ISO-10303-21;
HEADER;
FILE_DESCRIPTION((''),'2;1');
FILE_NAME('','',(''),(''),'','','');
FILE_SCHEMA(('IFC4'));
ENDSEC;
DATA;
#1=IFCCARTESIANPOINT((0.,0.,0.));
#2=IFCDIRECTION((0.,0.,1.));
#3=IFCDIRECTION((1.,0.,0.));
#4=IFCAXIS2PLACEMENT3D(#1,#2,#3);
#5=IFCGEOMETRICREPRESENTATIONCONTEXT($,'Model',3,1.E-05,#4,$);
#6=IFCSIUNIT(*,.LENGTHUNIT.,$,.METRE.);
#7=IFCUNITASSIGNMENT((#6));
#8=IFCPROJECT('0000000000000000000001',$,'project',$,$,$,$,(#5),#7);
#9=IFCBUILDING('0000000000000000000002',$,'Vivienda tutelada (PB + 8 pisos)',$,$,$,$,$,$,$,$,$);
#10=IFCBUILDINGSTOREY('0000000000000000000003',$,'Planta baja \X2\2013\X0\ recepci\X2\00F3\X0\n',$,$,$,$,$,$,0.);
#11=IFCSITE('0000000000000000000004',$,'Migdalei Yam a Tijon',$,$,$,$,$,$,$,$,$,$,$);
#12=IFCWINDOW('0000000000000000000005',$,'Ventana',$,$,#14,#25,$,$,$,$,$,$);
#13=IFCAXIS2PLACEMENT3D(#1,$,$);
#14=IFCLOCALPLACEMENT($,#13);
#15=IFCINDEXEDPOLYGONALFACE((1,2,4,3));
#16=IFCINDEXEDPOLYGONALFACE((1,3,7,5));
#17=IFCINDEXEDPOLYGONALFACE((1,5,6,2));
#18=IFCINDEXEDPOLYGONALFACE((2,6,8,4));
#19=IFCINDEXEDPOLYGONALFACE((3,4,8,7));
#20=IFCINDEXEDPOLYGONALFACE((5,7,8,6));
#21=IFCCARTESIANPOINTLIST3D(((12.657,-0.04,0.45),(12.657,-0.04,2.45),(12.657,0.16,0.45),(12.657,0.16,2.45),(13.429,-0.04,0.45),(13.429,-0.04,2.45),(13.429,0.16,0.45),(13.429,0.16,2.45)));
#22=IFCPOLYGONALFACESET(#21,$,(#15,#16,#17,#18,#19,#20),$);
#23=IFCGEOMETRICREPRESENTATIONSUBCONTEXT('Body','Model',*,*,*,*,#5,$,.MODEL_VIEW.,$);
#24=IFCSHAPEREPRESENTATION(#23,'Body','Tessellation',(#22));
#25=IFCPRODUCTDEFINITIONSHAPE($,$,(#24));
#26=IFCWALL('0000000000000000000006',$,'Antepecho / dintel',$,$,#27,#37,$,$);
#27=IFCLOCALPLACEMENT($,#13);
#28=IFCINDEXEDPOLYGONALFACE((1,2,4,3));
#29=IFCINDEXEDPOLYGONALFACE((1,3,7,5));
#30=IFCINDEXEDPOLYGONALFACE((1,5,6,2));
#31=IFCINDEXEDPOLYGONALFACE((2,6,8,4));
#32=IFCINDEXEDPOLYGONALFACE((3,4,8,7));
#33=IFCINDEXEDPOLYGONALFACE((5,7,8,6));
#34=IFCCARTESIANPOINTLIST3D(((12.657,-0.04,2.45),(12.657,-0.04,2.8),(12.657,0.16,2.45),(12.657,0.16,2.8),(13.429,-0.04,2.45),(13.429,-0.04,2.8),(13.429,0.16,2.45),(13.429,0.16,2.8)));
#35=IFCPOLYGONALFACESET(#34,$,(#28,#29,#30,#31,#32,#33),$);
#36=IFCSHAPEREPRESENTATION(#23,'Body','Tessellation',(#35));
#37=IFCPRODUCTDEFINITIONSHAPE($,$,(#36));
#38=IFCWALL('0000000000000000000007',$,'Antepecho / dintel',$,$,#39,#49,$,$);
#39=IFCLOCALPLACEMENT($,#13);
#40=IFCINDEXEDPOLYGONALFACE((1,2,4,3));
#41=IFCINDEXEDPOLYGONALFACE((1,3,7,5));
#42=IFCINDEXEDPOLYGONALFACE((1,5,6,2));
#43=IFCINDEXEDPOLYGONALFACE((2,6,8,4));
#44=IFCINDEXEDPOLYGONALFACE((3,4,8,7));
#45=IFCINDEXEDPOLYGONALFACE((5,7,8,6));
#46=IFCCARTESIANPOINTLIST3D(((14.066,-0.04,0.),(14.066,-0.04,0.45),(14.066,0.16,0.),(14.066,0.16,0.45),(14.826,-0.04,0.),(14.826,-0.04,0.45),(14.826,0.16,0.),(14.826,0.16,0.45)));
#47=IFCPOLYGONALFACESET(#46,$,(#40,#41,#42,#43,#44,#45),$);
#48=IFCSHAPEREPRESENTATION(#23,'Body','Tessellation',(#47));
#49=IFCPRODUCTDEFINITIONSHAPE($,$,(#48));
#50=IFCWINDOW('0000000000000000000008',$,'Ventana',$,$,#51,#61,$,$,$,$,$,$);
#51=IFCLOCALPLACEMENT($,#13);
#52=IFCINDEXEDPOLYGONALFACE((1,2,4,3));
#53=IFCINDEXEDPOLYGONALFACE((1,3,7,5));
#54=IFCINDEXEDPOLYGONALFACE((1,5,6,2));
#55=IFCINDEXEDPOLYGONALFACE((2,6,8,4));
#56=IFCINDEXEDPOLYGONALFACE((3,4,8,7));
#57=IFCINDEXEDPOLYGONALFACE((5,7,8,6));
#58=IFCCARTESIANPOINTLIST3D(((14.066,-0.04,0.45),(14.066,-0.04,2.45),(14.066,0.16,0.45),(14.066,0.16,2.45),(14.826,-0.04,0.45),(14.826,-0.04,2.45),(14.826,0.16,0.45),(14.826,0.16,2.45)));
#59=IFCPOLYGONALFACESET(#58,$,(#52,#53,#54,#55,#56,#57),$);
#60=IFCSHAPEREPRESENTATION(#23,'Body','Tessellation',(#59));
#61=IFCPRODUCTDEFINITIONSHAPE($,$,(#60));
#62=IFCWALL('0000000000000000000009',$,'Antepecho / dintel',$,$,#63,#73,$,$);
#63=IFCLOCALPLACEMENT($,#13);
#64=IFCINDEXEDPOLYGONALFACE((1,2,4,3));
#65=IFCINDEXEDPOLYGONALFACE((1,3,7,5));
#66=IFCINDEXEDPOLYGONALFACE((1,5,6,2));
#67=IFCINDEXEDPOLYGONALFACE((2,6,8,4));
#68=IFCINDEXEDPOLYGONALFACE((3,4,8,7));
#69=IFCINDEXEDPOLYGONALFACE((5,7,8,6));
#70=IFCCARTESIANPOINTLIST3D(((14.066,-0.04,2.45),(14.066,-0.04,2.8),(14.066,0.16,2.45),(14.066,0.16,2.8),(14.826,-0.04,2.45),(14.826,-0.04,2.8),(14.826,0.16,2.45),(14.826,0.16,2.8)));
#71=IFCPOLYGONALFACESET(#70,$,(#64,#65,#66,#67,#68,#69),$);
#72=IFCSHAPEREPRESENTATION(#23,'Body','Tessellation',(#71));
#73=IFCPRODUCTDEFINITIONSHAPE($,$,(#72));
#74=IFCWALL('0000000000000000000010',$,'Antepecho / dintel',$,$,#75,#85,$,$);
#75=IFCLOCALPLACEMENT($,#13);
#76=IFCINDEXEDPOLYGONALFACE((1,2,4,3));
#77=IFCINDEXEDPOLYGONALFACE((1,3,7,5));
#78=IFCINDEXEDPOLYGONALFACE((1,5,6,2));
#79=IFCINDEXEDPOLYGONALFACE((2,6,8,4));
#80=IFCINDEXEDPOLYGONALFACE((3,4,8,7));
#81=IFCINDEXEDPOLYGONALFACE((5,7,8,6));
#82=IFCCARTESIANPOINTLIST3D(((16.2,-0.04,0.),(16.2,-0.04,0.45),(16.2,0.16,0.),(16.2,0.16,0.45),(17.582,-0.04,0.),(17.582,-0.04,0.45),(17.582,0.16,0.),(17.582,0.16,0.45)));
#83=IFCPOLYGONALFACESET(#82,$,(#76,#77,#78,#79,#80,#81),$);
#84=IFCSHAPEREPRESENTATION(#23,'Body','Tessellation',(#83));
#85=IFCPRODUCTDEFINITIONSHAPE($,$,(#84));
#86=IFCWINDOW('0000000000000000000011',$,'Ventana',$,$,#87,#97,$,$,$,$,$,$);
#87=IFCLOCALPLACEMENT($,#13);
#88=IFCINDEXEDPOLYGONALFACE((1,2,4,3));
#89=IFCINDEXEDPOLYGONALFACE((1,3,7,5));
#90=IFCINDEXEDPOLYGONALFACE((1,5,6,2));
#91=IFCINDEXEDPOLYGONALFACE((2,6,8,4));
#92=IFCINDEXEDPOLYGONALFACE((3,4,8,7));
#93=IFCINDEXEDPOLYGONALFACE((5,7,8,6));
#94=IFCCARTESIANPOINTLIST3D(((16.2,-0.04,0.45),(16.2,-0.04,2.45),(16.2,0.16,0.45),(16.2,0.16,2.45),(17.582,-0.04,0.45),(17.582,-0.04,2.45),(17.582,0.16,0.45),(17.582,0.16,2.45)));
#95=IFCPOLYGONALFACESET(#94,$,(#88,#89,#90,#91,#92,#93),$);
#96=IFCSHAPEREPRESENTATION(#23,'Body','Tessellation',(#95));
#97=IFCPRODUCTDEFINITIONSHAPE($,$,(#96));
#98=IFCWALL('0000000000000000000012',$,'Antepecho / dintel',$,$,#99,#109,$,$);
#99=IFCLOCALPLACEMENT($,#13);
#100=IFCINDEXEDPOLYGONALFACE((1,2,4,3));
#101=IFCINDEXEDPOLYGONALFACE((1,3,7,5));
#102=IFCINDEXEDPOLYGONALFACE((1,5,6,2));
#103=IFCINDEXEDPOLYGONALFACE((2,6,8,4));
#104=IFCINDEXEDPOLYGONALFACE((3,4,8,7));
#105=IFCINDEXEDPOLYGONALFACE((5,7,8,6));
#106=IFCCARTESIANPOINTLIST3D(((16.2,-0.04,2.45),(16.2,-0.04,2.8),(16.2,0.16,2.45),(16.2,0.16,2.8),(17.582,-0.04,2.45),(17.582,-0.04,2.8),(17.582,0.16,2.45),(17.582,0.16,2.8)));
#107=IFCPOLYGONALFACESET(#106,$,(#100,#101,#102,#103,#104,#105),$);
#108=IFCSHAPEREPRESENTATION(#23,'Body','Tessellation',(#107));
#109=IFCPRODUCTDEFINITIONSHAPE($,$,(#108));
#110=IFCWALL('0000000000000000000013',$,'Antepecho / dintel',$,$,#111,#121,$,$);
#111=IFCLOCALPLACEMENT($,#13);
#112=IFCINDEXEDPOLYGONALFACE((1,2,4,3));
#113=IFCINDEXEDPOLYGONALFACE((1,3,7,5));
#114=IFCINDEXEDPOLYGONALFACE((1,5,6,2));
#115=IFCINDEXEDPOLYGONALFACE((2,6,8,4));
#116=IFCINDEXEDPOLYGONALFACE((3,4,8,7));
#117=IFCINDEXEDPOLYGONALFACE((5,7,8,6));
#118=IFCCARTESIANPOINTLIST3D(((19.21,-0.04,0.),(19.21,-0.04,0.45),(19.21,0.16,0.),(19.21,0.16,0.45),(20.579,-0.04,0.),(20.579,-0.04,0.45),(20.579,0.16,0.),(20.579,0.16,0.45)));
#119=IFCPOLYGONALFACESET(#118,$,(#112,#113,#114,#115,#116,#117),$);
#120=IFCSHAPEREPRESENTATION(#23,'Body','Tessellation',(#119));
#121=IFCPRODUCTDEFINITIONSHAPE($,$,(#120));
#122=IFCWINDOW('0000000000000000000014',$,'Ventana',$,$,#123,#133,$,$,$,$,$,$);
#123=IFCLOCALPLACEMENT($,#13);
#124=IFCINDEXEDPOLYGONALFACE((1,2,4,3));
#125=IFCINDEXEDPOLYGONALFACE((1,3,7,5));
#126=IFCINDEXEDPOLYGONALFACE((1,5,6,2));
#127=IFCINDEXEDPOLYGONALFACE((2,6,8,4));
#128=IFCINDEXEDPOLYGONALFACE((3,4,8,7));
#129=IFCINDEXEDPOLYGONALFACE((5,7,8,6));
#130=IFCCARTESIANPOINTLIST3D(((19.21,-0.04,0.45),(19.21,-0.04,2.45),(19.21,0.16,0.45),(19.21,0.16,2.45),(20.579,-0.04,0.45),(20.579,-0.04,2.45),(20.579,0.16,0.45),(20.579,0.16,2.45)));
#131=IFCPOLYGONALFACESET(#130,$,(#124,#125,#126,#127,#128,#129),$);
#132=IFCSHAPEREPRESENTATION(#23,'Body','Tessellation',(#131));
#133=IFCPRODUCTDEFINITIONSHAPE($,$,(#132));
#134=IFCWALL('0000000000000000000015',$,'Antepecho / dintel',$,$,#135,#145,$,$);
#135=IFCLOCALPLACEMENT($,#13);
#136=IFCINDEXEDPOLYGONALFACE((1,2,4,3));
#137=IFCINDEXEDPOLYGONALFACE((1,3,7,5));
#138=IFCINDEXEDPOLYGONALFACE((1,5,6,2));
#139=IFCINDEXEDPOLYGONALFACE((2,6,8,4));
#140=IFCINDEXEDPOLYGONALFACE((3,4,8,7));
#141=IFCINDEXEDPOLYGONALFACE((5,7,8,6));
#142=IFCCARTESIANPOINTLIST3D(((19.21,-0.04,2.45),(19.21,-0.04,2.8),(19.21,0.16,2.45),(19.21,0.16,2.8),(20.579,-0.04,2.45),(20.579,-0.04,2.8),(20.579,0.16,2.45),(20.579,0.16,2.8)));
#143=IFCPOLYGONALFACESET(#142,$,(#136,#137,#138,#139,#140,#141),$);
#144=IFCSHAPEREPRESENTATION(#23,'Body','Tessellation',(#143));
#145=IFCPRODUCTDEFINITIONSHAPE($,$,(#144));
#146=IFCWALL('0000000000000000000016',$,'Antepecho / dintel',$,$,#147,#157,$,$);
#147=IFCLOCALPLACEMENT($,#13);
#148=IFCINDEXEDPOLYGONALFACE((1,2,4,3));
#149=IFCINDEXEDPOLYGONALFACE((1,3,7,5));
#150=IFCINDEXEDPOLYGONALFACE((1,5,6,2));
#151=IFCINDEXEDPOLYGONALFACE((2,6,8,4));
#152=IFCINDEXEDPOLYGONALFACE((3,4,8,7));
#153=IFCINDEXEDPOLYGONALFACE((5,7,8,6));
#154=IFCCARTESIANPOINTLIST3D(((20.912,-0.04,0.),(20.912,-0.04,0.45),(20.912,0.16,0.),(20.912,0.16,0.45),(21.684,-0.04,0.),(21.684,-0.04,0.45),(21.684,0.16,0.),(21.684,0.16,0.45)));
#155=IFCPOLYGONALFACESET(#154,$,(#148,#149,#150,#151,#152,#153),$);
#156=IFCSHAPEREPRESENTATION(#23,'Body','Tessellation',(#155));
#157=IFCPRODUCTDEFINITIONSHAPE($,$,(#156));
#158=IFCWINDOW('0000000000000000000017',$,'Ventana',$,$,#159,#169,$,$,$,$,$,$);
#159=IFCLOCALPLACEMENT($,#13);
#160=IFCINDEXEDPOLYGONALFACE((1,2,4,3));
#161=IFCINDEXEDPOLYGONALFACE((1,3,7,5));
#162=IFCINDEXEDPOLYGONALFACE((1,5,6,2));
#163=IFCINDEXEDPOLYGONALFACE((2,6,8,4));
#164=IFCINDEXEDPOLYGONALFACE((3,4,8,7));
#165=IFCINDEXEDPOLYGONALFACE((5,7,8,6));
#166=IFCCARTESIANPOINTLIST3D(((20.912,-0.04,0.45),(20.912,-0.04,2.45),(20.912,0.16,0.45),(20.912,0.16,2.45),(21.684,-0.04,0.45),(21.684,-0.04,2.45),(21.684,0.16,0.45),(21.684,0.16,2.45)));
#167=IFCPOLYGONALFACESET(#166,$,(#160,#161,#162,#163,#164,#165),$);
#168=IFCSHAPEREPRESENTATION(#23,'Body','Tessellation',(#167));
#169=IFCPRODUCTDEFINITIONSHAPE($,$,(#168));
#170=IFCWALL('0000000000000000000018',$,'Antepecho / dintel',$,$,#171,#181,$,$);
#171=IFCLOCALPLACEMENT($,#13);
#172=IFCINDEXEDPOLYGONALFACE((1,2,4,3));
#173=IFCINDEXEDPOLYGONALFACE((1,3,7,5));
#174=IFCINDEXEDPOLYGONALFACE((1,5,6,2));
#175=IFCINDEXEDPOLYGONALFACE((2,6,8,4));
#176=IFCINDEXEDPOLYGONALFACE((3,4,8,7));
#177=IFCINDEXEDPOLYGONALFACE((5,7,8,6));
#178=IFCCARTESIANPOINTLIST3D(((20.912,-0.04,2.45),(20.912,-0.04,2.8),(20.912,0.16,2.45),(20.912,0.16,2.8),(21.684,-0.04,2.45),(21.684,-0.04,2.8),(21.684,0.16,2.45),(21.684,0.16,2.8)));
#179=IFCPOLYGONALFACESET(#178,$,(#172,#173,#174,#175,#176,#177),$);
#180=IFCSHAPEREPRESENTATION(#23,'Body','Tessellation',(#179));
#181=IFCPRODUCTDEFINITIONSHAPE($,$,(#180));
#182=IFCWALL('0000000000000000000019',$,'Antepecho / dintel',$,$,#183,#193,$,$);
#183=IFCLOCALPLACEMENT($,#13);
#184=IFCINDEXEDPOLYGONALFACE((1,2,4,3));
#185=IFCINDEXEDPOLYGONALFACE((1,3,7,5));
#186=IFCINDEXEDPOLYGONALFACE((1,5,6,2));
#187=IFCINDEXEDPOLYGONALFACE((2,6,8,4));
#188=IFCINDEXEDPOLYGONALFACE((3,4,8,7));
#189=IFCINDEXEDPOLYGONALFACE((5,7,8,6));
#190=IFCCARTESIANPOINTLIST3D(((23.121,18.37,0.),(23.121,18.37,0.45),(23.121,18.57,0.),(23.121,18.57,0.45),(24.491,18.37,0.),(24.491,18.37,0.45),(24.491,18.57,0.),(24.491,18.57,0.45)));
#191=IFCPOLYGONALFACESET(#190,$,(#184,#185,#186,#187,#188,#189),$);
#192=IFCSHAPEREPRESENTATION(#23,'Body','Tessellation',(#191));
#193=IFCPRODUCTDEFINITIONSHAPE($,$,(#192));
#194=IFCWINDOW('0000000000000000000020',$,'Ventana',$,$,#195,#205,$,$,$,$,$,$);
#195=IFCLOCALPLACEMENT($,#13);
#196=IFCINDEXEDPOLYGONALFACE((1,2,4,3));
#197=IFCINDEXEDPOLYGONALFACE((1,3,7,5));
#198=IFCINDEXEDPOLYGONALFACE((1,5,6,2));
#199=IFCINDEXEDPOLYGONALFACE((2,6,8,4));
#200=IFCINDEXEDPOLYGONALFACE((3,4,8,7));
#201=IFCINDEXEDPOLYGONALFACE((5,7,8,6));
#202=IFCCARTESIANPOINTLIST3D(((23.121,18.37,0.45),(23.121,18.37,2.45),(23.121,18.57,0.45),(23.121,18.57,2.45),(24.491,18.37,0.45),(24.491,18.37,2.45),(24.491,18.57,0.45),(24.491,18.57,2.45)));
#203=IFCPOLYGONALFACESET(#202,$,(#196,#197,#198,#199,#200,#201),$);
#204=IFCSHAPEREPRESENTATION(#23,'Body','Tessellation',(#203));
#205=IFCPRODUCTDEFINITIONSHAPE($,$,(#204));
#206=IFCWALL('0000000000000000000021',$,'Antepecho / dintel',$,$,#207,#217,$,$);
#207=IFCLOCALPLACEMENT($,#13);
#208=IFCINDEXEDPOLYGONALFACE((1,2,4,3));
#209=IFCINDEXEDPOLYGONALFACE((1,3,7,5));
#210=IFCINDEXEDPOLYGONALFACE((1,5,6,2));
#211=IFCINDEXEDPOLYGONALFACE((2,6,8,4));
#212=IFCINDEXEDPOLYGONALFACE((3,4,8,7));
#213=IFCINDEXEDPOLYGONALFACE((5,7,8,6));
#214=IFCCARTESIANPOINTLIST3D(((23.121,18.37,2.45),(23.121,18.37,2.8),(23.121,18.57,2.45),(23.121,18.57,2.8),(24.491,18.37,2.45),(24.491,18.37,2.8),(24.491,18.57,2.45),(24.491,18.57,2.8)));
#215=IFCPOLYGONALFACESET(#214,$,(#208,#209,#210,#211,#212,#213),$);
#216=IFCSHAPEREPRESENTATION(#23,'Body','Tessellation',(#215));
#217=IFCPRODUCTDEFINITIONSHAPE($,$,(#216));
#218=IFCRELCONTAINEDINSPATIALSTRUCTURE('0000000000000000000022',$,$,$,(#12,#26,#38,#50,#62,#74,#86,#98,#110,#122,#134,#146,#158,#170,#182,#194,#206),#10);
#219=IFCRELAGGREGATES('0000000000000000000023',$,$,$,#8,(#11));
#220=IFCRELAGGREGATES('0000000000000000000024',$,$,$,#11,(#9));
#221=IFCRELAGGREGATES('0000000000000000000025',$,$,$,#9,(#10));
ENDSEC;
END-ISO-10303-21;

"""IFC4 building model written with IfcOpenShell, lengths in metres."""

from ifc_helpers import new_model, si_unit, frame, origin_with_axes, context, subcontext, project, spatial, line, indexed_curve, outline, extrude, element, save


model = new_model("IFC4")

# Units and contexts
model_context = context("Model", 3, precision=1e-05, world=origin_with_axes())
body_context = subcontext(model_context, "Body", "Model", "MODEL_VIEW")
ifc_project = project(units=[si_unit("LENGTHUNIT", "METRE")], contexts=[model_context])

# Site, building, storey
site = spatial("IfcSite", under=ifc_project, Name="Migdalei Yam a Tijon")
building = spatial("IfcBuilding", under=site, Name="Vivienda tutelada (PB + 8 pisos)")
storey = spatial("IfcBuildingStorey", under=building, Name="Planta baja – recepción", Elevation=0.0)

# Window
element("IfcWindow", 1, inside=storey, Name="Ventana", context=body_context, shape_type="SweptSolid", body=[
    extrude(outline(indexed_curve([(0.0, 0.0), (0.772, 0.0), (0.772, 0.2), (0.0, 0.2)], segments=[line(1, 2, 3, 4, 1)])), frame((12.657, -0.04, 0.45), z_axis=(0.0, 0.0, 1.0), x_axis=(1.0, 0.0, 0.0)), (0.0, 0.0, 1.0), 2.0),
])

# Walls
element("IfcWall", 2, inside=storey, Name="Antepecho / dintel", context=body_context, shape_type="SweptSolid", body=[
    extrude(outline(indexed_curve([(0.0, 0.0), (0.772, 0.0), (0.772, 0.2), (0.0, 0.2)], segments=[line(1, 2, 3, 4, 1)])), frame((12.657, -0.04, 2.45), z_axis=(0.0, 0.0, 1.0), x_axis=(1.0, 0.0, 0.0)), (0.0, 0.0, 1.0), 0.35),
])
element("IfcWall", 3, inside=storey, Name="Antepecho / dintel", context=body_context, shape_type="SweptSolid", body=[
    extrude(outline(indexed_curve([(0.0, 0.0), (0.76, 0.0), (0.76, 0.2), (0.0, 0.2)], segments=[line(1, 2, 3, 4, 1)])), frame((14.066, -0.04, 0.0), z_axis=(0.0, 0.0, 1.0), x_axis=(1.0, 0.0, 0.0)), (0.0, 0.0, 1.0), 0.45),
])

# Window
element("IfcWindow", 4, inside=storey, Name="Ventana", context=body_context, shape_type="SweptSolid", body=[
    extrude(outline(indexed_curve([(0.0, 0.0), (0.76, 0.0), (0.76, 0.2), (0.0, 0.2)], segments=[line(1, 2, 3, 4, 1)])), frame((14.066, -0.04, 0.45), z_axis=(0.0, 0.0, 1.0), x_axis=(1.0, 0.0, 0.0)), (0.0, 0.0, 1.0), 2.0),
])

# Walls
element("IfcWall", 5, inside=storey, Name="Antepecho / dintel", context=body_context, shape_type="SweptSolid", body=[
    extrude(outline(indexed_curve([(0.0, 0.0), (0.76, 0.0), (0.76, 0.2), (0.0, 0.2)], segments=[line(1, 2, 3, 4, 1)])), frame((14.066, -0.04, 2.45), z_axis=(0.0, 0.0, 1.0), x_axis=(1.0, 0.0, 0.0)), (0.0, 0.0, 1.0), 0.35),
])
element("IfcWall", 6, inside=storey, Name="Antepecho / dintel", context=body_context, shape_type="SweptSolid", body=[
    extrude(outline(indexed_curve([(0.0, 0.0), (1.382, 0.0), (1.382, 0.2), (0.0, 0.2)], segments=[line(1, 2, 3, 4, 1)])), frame((16.2, -0.04, 0.0), z_axis=(0.0, 0.0, 1.0), x_axis=(1.0, 0.0, 0.0)), (0.0, 0.0, 1.0), 0.45),
])

# Window
element("IfcWindow", 7, inside=storey, Name="Ventana", context=body_context, shape_type="SweptSolid", body=[
    extrude(outline(indexed_curve([(0.0, 0.0), (1.382, 0.0), (1.382, 0.2), (0.0, 0.2)], segments=[line(1, 2, 3, 4, 1)])), frame((16.2, -0.04, 0.45), z_axis=(0.0, 0.0, 1.0), x_axis=(1.0, 0.0, 0.0)), (0.0, 0.0, 1.0), 2.0),
])

# Walls
element("IfcWall", 8, inside=storey, Name="Antepecho / dintel", context=body_context, shape_type="SweptSolid", body=[
    extrude(outline(indexed_curve([(0.0, 0.0), (1.382, 0.0), (1.382, 0.2), (0.0, 0.2)], segments=[line(1, 2, 3, 4, 1)])), frame((16.2, -0.04, 2.45), z_axis=(0.0, 0.0, 1.0), x_axis=(1.0, 0.0, 0.0)), (0.0, 0.0, 1.0), 0.35),
])
element("IfcWall", 9, inside=storey, Name="Antepecho / dintel", context=body_context, shape_type="SweptSolid", body=[
    extrude(outline(indexed_curve([(0.0, 0.0), (1.369, 0.0), (1.369, 0.2), (0.0, 0.2)], segments=[line(1, 2, 3, 4, 1)])), frame((19.21, -0.04, 0.0), z_axis=(0.0, 0.0, 1.0), x_axis=(1.0, 0.0, 0.0)), (0.0, 0.0, 1.0), 0.45),
])

# Window
element("IfcWindow", 10, inside=storey, Name="Ventana", context=body_context, shape_type="SweptSolid", body=[
    extrude(outline(indexed_curve([(0.0, 0.0), (1.369, 0.0), (1.369, 0.2), (0.0, 0.2)], segments=[line(1, 2, 3, 4, 1)])), frame((19.21, -0.04, 0.45), z_axis=(0.0, 0.0, 1.0), x_axis=(1.0, 0.0, 0.0)), (0.0, 0.0, 1.0), 2.0),
])

# Walls
element("IfcWall", 11, inside=storey, Name="Antepecho / dintel", context=body_context, shape_type="SweptSolid", body=[
    extrude(outline(indexed_curve([(0.0, 0.0), (1.369, 0.0), (1.369, 0.2), (0.0, 0.2)], segments=[line(1, 2, 3, 4, 1)])), frame((19.21, -0.04, 2.45), z_axis=(0.0, 0.0, 1.0), x_axis=(1.0, 0.0, 0.0)), (0.0, 0.0, 1.0), 0.35),
])
element("IfcWall", 12, inside=storey, Name="Antepecho / dintel", context=body_context, shape_type="SweptSolid", body=[
    extrude(outline(indexed_curve([(0.0, 0.0), (0.772, 0.0), (0.772, 0.2), (0.0, 0.2)], segments=[line(1, 2, 3, 4, 1)])), frame((20.912, -0.04, 0.0), z_axis=(0.0, 0.0, 1.0), x_axis=(1.0, 0.0, 0.0)), (0.0, 0.0, 1.0), 0.45),
])

# Window
element("IfcWindow", 13, inside=storey, Name="Ventana", context=body_context, shape_type="SweptSolid", body=[
    extrude(outline(indexed_curve([(0.0, 0.0), (0.772, 0.0), (0.772, 0.2), (0.0, 0.2)], segments=[line(1, 2, 3, 4, 1)])), frame((20.912, -0.04, 0.45), z_axis=(0.0, 0.0, 1.0), x_axis=(1.0, 0.0, 0.0)), (0.0, 0.0, 1.0), 2.0),
])

# Walls
element("IfcWall", 14, inside=storey, Name="Antepecho / dintel", context=body_context, shape_type="SweptSolid", body=[
    extrude(outline(indexed_curve([(0.0, 0.0), (0.772, 0.0), (0.772, 0.2), (0.0, 0.2)], segments=[line(1, 2, 3, 4, 1)])), frame((20.912, -0.04, 2.45), z_axis=(0.0, 0.0, 1.0), x_axis=(1.0, 0.0, 0.0)), (0.0, 0.0, 1.0), 0.35),
])
element("IfcWall", 15, inside=storey, Name="Antepecho / dintel", context=body_context, shape_type="SweptSolid", body=[
    extrude(outline(indexed_curve([(0.0, 0.0), (1.37, 0.0), (1.37, 0.2), (0.0, 0.2)], segments=[line(1, 2, 3, 4, 1)])), frame((23.121, 18.37, 0.0), z_axis=(0.0, 0.0, 1.0), x_axis=(1.0, 0.0, 0.0)), (0.0, 0.0, 1.0), 0.45),
])

# Window
element("IfcWindow", 16, inside=storey, Name="Ventana", context=body_context, shape_type="SweptSolid", body=[
    extrude(outline(indexed_curve([(0.0, 0.0), (1.37, 0.0), (1.37, 0.2), (0.0, 0.2)], segments=[line(1, 2, 3, 4, 1)])), frame((23.121, 18.37, 0.45), z_axis=(0.0, 0.0, 1.0), x_axis=(1.0, 0.0, 0.0)), (0.0, 0.0, 1.0), 2.0),
])

# Wall
element("IfcWall", 17, inside=storey, Name="Antepecho / dintel", context=body_context, shape_type="SweptSolid", body=[
    extrude(outline(indexed_curve([(0.0, 0.0), (1.37, 0.0), (1.37, 0.2), (0.0, 0.2)], segments=[line(1, 2, 3, 4, 1)])), frame((23.121, 18.37, 2.45), z_axis=(0.0, 0.0, 1.0), x_axis=(1.0, 0.0, 0.0)), (0.0, 0.0, 1.0), 0.35),
])

save(model, "model.ifc")
